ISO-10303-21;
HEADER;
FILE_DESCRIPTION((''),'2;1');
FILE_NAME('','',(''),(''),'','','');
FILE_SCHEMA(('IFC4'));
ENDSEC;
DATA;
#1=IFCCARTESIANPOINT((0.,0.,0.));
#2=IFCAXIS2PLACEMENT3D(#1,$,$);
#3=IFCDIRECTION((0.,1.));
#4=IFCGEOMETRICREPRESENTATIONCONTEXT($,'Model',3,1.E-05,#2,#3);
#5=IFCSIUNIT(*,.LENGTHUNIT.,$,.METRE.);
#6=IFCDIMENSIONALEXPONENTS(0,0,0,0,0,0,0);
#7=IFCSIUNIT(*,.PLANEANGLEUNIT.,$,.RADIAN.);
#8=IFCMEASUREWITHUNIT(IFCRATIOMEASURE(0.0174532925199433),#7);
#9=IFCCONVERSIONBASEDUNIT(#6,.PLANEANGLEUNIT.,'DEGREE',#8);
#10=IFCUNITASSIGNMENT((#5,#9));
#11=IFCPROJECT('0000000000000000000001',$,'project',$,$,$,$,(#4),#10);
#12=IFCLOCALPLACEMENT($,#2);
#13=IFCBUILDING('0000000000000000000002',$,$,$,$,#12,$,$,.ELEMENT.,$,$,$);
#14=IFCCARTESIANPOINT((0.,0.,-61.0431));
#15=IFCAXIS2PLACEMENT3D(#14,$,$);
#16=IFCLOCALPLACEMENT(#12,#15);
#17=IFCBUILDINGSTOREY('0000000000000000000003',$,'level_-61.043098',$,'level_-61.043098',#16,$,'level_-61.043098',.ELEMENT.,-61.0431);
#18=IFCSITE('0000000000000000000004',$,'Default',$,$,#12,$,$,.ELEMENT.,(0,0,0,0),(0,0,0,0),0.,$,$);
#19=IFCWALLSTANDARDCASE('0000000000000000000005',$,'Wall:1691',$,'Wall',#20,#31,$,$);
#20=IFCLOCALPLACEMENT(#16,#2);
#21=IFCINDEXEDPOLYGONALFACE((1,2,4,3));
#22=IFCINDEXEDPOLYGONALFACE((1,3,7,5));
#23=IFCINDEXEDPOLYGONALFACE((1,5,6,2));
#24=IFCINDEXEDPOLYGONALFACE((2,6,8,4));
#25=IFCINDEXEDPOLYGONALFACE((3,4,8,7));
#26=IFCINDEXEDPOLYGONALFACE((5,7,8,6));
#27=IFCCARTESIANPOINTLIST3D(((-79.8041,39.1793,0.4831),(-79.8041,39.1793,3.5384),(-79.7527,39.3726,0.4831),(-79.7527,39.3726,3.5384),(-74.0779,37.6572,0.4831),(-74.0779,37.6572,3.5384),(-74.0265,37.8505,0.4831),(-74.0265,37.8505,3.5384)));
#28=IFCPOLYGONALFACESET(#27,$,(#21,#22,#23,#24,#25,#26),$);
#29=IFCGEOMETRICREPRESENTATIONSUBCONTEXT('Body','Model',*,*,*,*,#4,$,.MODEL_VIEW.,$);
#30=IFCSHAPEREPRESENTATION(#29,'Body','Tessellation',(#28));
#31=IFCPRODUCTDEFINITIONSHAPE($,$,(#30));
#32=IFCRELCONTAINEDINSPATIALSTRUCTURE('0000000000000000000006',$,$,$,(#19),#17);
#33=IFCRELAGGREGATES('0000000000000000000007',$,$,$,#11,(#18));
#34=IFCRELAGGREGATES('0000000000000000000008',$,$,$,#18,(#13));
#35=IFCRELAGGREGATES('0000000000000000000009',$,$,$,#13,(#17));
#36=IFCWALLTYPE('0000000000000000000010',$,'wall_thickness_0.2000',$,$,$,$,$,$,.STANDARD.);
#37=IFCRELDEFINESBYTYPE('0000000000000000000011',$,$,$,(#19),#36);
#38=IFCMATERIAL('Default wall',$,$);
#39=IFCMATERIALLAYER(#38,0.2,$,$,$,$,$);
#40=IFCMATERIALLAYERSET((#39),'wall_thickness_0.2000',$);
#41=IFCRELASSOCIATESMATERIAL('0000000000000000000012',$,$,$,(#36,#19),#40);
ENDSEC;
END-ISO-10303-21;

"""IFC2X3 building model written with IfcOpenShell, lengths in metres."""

from ifc_helpers import new_model, entity, si_unit, converted_unit, direction, frame, origin, place, context, subcontext, project, spatial, polyline, outline, extrude, material, layer, layer_set, layer_usage, type_object, element, save


model = new_model("IFC2X3")

# Units and contexts
model_context = context("Model", 3, precision=1e-05, world=origin(), true_north=direction((0.0, 1.0)))
body_context = subcontext(model_context, "Body", "Model", "MODEL_VIEW")
ifc_project = project(units=[si_unit("LENGTHUNIT", "METRE"), converted_unit("PLANEANGLEUNIT", "DEGREE", entity("IfcRatioMeasure", 0.0174532925199433), si_unit("PLANEANGLEUNIT", "RADIAN"), dimensions=[0, 0, 0, 0, 0, 0, 0])], contexts=[model_context])

# Site, building, storey
placement_1 = place(None, origin())
site = spatial("IfcSite", under=ifc_project, at=placement_1, Name="Default", CompositionType="ELEMENT", RefLatitude=(0, 0, 0, 0), RefLongitude=(0, 0, 0, 0), RefElevation=0.0)
building = spatial("IfcBuilding", under=site, at=placement_1, CompositionType="ELEMENT")
storey_placement = place(placement_1, frame((0.0, 0.0, -61.0431)))
storey = spatial("IfcBuildingStorey", under=building, at=storey_placement, Name="level_-61.043098", ObjectType="level_-61.043098", LongName="level_-61.043098", CompositionType="ELEMENT", Elevation=-61.0431)

# Shared definitions
ifc_material_1 = material(Name="Default wall")
ifc_layer = layer(ifc_material_1, 0.2)
ifc_layer_set = layer_set([ifc_layer], Name="wall_thickness_0.2000")
ifc_layer_usage = layer_usage(ifc_layer_set, "AXIS2", "POSITIVE", -0.1)
wall_type = type_object("IfcWallType", Name="wall_thickness_0.2000", PredefinedType="STANDARD", material=ifc_layer_set)

# Wall
placement_2 = place(placement_1, frame((0.0, 0.0, -60.56)))
wall_1_placement = place(placement_2, frame((-79.7784, 39.2759, 0.0), z_axis=(0.0, 0.0, 1.0), x_axis=(0.966442, -0.256885, 0.0)))
element("IfcWallStandardCase", 1, at=wall_1_placement, inside=storey, type_object=wall_type, material=ifc_layer_usage, Name="Wall:1691", ObjectType="Wall", context=body_context, shape_type="SweptSolid", body=[
    extrude(outline(polyline([(5.925, -0.1), (5.925, 0.1), (0.0, 0.1), (0.0, -0.1), (5.925, -0.1)])), origin(), (0.0, 0.0, 1.0), 3.0554),
])

save(model, "model.ifc")
